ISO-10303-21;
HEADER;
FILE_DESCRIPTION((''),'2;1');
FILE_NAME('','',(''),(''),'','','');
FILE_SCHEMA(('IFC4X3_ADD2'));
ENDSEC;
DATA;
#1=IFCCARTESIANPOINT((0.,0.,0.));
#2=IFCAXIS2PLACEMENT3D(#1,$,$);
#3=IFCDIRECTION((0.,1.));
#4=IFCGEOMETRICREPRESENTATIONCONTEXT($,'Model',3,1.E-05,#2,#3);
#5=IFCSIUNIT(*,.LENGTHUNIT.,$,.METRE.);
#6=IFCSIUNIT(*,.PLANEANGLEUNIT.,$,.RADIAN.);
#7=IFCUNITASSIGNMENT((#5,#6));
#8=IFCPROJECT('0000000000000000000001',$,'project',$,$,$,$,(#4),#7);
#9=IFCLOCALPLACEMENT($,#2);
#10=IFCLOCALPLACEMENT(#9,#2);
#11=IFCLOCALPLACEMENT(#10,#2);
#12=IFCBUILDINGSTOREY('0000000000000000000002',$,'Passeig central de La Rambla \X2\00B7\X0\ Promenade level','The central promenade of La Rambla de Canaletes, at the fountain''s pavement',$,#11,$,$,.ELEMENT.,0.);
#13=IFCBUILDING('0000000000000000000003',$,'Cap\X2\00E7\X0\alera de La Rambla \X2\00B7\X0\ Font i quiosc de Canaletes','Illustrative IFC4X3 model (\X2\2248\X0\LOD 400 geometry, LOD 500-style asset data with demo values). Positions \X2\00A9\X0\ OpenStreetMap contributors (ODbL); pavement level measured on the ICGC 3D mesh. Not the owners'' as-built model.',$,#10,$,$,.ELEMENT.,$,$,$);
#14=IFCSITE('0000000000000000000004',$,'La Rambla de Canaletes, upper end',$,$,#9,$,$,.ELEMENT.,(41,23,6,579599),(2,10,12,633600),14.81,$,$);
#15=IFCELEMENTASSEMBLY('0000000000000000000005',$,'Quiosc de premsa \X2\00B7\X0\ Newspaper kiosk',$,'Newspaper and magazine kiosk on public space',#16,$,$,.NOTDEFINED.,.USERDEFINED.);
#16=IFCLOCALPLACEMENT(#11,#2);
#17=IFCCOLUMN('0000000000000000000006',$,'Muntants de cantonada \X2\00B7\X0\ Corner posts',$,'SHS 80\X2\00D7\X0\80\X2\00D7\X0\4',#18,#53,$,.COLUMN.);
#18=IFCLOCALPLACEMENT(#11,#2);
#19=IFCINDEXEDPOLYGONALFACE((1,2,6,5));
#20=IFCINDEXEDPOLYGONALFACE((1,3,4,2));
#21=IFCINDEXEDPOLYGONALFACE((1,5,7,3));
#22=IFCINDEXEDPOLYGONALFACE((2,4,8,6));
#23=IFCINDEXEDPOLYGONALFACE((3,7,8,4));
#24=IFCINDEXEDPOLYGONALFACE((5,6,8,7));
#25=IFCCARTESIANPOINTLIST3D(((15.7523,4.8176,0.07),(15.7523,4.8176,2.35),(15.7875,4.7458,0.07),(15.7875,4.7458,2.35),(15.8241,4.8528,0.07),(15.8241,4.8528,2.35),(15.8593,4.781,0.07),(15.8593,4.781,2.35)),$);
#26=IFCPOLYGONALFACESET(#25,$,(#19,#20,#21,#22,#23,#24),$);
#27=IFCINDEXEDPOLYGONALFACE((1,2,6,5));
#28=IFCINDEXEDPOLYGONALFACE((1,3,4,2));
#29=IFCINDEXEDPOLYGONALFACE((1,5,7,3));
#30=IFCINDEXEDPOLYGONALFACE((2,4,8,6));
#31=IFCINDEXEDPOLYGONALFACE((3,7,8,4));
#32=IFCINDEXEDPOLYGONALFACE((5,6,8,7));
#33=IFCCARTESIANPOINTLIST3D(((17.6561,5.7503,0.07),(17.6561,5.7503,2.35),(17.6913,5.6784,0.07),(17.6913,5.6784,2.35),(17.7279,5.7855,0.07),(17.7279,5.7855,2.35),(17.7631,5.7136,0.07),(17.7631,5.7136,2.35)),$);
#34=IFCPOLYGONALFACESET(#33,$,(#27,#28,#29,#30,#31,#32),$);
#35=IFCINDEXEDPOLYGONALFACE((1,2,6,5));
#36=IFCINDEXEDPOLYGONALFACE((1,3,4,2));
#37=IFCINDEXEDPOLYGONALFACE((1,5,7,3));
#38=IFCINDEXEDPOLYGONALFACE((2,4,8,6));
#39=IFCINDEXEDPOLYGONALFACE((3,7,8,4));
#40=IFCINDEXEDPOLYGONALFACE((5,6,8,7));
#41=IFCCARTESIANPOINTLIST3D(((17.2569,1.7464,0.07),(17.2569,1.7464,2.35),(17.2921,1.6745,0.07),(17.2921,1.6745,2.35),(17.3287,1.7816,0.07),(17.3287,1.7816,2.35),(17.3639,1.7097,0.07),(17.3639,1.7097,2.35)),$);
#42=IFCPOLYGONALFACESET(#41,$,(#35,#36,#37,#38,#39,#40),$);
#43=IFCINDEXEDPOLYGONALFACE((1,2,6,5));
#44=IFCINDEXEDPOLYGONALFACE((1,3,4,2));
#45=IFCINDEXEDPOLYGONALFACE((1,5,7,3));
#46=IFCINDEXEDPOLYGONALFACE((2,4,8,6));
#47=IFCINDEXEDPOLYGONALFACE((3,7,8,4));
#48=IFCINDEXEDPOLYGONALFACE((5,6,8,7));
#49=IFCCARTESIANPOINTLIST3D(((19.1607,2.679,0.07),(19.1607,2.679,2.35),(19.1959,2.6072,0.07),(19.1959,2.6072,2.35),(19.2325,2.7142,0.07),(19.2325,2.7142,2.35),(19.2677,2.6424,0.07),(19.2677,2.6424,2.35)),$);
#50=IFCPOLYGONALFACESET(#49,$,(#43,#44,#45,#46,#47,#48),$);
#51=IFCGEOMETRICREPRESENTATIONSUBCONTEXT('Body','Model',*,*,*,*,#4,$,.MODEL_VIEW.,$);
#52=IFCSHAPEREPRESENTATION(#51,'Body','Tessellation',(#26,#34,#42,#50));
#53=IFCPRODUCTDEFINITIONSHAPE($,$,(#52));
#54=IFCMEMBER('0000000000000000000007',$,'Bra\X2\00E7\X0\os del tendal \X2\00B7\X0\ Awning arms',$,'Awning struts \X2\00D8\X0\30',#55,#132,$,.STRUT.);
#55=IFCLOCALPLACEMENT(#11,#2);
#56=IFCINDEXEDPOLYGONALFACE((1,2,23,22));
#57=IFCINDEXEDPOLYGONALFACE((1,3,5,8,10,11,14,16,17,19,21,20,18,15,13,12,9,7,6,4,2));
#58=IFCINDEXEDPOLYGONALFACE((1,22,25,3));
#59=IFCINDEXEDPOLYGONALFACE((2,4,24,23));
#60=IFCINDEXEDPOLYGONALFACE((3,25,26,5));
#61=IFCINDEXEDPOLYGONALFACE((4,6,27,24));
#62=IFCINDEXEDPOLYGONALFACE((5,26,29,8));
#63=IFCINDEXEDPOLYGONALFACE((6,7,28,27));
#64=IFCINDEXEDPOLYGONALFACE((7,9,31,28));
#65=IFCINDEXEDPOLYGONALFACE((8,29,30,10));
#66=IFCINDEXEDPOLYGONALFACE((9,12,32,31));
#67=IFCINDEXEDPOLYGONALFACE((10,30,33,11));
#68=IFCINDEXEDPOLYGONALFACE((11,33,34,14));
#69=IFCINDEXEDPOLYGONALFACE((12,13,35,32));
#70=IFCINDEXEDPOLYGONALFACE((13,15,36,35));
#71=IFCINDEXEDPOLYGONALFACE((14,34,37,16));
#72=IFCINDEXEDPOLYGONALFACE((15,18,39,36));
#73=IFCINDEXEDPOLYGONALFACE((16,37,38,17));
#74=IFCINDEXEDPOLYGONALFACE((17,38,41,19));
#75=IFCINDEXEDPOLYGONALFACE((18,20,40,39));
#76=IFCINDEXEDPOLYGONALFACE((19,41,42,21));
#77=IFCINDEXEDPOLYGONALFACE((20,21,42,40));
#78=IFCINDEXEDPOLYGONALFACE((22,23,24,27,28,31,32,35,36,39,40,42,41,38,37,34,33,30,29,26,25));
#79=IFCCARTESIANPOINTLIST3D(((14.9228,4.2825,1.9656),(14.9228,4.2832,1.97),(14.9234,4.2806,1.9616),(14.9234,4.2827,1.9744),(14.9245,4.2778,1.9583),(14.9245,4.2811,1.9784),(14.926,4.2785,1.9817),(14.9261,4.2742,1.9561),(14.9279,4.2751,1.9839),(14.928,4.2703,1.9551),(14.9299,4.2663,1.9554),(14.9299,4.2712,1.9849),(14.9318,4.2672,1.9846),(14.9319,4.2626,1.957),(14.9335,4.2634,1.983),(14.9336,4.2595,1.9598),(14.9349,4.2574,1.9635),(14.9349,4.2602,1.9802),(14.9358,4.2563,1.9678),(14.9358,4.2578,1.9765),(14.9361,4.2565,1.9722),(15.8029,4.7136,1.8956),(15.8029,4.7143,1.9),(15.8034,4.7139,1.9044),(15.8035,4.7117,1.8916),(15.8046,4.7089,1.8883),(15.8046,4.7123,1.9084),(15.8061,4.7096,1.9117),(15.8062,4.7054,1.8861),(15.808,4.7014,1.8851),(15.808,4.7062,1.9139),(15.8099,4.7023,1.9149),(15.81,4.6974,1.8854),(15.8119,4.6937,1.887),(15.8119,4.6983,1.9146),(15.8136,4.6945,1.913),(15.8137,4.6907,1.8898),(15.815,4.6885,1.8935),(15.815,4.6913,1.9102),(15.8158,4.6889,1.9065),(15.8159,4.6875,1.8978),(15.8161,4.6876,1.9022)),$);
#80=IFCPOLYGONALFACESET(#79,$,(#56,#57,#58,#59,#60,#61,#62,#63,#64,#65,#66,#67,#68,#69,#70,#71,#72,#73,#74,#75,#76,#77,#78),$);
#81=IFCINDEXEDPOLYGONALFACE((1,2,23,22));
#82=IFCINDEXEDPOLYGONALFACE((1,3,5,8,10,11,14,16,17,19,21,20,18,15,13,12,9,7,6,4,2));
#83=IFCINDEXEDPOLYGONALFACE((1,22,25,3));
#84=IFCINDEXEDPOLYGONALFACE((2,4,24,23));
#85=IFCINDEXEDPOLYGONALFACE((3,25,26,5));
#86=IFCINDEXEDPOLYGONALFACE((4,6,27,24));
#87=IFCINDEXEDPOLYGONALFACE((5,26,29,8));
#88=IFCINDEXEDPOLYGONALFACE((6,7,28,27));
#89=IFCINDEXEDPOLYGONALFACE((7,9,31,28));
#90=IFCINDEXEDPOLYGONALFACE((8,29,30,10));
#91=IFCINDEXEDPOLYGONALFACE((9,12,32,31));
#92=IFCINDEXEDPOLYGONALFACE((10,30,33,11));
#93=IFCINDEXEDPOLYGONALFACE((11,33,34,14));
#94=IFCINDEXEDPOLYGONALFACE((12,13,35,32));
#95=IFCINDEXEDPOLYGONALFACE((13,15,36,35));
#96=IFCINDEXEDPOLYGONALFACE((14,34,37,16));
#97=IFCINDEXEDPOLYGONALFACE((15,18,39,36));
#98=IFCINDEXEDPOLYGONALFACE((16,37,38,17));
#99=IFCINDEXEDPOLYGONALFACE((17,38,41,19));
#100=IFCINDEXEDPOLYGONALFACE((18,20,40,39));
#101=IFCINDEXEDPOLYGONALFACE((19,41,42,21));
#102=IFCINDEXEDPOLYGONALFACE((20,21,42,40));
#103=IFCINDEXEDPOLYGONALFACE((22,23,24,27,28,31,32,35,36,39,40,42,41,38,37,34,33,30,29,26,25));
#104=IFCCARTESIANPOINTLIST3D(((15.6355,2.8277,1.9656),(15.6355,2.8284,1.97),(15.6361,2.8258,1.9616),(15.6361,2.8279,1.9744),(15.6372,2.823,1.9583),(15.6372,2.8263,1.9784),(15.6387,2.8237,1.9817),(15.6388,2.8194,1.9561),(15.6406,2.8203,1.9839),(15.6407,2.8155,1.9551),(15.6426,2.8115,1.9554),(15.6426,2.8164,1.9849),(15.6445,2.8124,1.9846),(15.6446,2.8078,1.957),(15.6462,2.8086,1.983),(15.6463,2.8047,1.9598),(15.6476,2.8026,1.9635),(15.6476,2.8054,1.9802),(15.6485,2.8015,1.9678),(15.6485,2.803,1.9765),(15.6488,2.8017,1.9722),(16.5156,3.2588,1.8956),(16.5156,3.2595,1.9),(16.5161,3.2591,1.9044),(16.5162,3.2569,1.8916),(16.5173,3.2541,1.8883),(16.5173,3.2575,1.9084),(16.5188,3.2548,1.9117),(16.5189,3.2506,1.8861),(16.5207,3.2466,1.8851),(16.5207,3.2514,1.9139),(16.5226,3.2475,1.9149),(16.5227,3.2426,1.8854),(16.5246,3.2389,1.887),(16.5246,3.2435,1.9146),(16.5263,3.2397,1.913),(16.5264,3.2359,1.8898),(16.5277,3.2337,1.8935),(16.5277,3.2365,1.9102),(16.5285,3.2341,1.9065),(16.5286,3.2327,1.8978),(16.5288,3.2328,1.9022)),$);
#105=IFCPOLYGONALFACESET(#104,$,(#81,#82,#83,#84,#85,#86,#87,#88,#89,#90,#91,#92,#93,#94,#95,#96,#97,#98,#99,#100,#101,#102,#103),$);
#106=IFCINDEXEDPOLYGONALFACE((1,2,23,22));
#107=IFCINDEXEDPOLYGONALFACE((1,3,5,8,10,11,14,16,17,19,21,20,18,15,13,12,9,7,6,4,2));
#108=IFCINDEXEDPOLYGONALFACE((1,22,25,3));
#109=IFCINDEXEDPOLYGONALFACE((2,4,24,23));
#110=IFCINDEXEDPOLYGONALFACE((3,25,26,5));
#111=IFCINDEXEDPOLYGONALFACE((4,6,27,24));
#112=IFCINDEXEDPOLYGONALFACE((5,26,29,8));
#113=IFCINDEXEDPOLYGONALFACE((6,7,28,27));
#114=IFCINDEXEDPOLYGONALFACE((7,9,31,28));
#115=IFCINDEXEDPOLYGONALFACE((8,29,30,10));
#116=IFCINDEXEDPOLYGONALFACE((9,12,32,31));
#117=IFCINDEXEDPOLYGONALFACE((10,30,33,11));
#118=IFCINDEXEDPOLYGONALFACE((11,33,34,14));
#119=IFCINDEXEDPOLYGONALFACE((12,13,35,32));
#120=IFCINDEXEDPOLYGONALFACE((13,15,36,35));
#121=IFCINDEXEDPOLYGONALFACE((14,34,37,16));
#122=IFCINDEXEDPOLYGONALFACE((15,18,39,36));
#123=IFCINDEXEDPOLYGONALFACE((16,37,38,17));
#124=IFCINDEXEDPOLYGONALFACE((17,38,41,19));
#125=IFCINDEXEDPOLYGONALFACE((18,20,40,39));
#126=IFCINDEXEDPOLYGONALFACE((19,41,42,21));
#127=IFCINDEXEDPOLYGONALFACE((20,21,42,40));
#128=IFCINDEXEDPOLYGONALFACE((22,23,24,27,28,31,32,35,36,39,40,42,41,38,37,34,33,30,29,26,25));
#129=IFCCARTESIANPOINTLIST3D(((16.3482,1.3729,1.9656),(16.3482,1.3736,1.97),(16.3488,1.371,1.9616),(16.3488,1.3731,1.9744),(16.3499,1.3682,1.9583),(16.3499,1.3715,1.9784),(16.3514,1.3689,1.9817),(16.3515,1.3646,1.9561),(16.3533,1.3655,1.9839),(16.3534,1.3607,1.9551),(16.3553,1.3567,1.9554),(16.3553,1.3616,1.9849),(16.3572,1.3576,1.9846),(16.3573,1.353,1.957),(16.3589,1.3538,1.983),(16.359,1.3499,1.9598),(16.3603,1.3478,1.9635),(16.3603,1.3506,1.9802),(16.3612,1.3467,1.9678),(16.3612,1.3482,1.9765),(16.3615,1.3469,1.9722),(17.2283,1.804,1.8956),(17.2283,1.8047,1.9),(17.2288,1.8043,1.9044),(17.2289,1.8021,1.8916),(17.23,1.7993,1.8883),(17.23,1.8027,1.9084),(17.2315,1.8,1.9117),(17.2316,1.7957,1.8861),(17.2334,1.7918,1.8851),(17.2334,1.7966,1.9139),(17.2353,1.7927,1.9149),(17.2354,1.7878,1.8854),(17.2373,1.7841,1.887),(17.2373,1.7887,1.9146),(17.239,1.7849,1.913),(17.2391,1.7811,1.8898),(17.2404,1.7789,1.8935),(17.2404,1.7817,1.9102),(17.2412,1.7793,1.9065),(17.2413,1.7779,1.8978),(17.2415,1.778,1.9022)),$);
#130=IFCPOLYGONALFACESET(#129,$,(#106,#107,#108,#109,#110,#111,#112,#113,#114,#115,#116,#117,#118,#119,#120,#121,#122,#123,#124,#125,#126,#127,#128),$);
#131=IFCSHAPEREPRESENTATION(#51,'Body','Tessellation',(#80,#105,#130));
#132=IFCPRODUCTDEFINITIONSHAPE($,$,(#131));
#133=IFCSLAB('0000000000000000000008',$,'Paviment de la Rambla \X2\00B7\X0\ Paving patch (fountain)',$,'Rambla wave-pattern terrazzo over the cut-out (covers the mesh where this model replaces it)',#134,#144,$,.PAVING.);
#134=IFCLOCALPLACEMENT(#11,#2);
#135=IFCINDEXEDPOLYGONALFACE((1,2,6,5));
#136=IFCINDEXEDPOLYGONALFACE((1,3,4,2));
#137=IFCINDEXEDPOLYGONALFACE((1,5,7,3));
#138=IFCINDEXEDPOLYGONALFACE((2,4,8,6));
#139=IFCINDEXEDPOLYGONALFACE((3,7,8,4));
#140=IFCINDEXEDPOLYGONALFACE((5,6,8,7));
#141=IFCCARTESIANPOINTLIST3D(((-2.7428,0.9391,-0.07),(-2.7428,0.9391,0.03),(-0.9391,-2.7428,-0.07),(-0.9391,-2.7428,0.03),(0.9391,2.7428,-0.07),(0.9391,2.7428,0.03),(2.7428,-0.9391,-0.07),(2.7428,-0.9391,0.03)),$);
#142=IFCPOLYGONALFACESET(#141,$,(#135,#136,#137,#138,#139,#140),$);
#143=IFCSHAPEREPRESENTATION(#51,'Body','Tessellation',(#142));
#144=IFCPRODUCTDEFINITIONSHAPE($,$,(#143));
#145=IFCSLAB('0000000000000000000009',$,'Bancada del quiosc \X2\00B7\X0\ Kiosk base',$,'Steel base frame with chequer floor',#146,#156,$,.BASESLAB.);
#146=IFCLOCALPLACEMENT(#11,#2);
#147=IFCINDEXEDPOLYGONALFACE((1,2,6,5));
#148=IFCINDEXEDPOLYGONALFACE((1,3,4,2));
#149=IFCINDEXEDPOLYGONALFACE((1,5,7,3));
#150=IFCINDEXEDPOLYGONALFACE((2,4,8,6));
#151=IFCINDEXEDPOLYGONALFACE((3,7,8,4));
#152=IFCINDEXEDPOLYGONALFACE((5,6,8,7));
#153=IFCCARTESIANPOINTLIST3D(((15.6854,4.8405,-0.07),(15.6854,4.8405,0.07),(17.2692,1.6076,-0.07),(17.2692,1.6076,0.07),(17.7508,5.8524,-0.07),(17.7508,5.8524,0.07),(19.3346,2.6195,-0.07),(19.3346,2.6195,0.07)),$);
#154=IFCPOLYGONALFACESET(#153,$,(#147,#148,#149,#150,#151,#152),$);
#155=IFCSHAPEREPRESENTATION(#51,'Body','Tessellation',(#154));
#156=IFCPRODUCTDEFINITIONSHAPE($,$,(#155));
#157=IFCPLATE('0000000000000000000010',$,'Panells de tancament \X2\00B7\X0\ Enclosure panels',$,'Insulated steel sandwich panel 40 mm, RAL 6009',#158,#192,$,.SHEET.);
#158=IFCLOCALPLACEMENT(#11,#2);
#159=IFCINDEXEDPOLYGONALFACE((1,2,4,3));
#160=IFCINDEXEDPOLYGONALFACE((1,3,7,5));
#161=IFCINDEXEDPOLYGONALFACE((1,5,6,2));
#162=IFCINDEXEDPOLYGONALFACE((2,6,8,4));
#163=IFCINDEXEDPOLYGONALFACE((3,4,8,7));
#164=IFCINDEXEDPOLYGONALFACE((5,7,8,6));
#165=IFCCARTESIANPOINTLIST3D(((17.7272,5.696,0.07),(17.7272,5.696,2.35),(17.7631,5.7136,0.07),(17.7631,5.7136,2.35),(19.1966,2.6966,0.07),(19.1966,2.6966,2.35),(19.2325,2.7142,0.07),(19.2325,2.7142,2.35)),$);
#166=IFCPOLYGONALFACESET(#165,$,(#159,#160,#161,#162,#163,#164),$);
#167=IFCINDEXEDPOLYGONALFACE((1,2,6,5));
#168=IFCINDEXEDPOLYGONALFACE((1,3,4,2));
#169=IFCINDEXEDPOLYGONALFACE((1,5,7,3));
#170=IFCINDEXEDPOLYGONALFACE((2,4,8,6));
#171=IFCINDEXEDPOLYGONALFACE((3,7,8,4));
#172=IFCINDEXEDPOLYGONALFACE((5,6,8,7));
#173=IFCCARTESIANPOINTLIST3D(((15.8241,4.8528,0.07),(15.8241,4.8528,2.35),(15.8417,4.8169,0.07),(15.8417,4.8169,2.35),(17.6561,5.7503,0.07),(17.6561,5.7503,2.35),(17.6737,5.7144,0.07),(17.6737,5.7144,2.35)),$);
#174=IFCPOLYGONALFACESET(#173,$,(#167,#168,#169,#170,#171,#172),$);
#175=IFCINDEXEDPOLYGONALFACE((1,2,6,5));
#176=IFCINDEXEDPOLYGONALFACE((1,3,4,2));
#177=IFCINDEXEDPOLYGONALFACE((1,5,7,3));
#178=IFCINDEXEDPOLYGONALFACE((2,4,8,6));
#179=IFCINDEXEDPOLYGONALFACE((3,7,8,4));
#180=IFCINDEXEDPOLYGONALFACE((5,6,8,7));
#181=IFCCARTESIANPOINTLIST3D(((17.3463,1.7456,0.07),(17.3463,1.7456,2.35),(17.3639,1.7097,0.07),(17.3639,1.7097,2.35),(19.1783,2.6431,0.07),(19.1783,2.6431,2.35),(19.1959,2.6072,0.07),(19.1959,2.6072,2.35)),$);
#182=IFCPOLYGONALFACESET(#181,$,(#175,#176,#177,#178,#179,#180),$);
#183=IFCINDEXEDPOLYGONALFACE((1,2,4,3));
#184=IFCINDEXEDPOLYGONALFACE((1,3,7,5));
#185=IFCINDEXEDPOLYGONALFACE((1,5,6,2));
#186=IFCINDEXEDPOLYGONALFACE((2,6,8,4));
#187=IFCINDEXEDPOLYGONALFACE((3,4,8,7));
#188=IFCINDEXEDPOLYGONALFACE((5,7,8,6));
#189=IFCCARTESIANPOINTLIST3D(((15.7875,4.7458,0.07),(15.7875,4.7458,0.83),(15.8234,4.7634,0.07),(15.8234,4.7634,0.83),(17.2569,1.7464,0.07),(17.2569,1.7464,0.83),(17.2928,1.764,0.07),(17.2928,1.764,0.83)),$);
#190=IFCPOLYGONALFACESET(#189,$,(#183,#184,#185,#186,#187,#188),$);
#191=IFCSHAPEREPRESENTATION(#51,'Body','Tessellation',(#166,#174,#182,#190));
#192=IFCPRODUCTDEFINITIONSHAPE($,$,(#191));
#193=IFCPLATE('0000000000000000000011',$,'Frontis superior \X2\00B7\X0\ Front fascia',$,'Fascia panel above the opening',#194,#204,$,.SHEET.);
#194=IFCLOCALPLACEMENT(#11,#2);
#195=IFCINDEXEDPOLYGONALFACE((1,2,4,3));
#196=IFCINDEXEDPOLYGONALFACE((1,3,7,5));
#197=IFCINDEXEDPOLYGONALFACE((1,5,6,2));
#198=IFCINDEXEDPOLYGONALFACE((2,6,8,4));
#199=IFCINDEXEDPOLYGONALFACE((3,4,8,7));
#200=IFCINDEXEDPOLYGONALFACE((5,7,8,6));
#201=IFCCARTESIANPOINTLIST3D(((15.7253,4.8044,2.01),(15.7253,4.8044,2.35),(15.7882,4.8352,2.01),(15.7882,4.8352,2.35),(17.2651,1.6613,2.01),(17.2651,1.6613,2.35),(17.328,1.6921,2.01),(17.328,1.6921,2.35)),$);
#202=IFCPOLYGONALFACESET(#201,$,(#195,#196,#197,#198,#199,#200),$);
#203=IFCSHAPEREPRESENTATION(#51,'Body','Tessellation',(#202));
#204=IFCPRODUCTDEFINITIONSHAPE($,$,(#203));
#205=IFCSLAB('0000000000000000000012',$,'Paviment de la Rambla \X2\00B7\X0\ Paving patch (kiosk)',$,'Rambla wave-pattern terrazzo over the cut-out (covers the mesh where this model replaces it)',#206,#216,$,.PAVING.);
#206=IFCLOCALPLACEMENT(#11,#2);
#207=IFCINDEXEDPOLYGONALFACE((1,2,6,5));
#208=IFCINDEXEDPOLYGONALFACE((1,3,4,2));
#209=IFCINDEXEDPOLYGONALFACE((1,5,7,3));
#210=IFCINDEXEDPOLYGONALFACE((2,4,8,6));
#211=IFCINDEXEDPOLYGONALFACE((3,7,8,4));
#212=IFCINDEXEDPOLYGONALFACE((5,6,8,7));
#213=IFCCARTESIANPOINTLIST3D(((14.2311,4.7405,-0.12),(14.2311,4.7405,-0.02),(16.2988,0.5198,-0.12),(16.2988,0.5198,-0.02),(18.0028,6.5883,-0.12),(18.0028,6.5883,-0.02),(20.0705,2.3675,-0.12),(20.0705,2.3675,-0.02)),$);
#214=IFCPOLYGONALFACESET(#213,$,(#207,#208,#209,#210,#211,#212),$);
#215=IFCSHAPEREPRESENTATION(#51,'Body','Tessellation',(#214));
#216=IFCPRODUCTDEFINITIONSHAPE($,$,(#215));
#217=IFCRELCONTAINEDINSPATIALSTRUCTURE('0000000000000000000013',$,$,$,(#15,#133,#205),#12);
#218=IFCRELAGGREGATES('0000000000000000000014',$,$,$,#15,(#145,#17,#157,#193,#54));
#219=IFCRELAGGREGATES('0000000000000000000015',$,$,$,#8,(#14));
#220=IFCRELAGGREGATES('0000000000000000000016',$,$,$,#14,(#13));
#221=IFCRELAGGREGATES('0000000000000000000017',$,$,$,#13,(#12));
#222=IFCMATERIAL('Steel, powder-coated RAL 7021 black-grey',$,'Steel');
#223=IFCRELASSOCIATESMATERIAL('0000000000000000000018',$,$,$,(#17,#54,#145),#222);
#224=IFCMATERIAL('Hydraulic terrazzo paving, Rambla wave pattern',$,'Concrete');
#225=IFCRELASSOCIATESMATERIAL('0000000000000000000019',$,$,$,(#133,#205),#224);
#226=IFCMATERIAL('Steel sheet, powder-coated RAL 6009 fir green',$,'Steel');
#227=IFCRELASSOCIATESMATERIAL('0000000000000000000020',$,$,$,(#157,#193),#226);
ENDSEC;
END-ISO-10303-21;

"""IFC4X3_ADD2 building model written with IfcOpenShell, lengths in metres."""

from ifc_helpers import new_model, si_unit, direction, frame, frame_2d, origin, origin_2d_with_axis, place, context, subcontext, project, spatial, rectangle, circle, extrude, material, element, aggregate, save


model = new_model("IFC4X3_ADD2")

# Units and contexts
model_context = context("Model", 3, precision=1e-05, world=origin(), true_north=direction((0.0, 1.0)))
body_context = subcontext(model_context, "Body", "Model", "MODEL_VIEW")
ifc_project = project(units=[si_unit("LENGTHUNIT", "METRE"), si_unit("PLANEANGLEUNIT", "RADIAN")], contexts=[model_context])

# Site, building, storey
site_placement = place(None, origin())
site = spatial("IfcSite", under=ifc_project, at=site_placement, Name="La Rambla de Canaletes, upper end", CompositionType="ELEMENT", RefLatitude=(41, 23, 6, 579599), RefLongitude=(2, 10, 12, 633600), RefElevation=14.81)
building_placement = place(site_placement, origin())
building = spatial("IfcBuilding", under=site, at=building_placement, Name="Capçalera de La Rambla · Font i quiosc de Canaletes", Description="Illustrative IFC4X3 model (≈LOD 400 geometry, LOD 500-style asset data with demo values). Positions © OpenStreetMap contributors (ODbL); pavement level measured on the ICGC 3D mesh. Not the owners' as-built model.", CompositionType="ELEMENT")
storey_placement = place(building_placement, origin())
storey = spatial("IfcBuildingStorey", under=building, at=storey_placement, Name="Passeig central de La Rambla · Promenade level", Description="The central promenade of La Rambla de Canaletes, at the fountain's pavement", CompositionType="ELEMENT", Elevation=0.0)

# Element assembly, column, member
assembly_1_placement = place(building_placement, origin())
assembly_1 = element("IfcElementAssembly", 1, at=assembly_1_placement, inside=storey, Name="Quiosc de premsa · Newspaper kiosk", ObjectType="Newspaper and magazine kiosk on public space", AssemblyPlace="NOTDEFINED", PredefinedType="USERDEFINED")
ifc_material_1 = material(Name="Steel, powder-coated RAL 7021 black-grey", Category="Steel")
column_placement = place(building_placement, origin())
column = element("IfcColumn", 2, at=column_placement, material=ifc_material_1, Name="Muntants de cantonada · Corner posts", ObjectType="SHS 80×80×4", PredefinedType="COLUMN", context=body_context, shape_type="SweptSolid", body=[
    extrude(rectangle(XDim=0.08, YDim=0.08, at=frame_2d((0.0, 0.0), x_axis=(0.439939, -0.898028))), frame((15.8058, 4.7993, 0.07)), (0.0, 0.0, 1.0), 2.28),
    extrude(rectangle(XDim=0.08, YDim=0.08, at=frame_2d((0.0, 0.0), x_axis=(0.439939, -0.898028))), frame((17.7096, 5.732, 0.07)), (0.0, 0.0, 1.0), 2.28),
    extrude(rectangle(XDim=0.08, YDim=0.08, at=frame_2d((0.0, 0.0), x_axis=(0.439939, -0.898028))), frame((17.3104, 1.728, 0.07)), (0.0, 0.0, 1.0), 2.28),
    extrude(rectangle(XDim=0.08, YDim=0.08, at=frame_2d((0.0, 0.0), x_axis=(0.439939, -0.898028))), frame((19.2142, 2.6607, 0.07)), (0.0, 0.0, 1.0), 2.28),
])
member_placement = place(building_placement, origin())
member = element("IfcMember", 3, at=member_placement, material=ifc_material_1, Name="Braços del tendal · Awning arms", ObjectType="Awning struts Ø30", PredefinedType="STRUT", context=body_context, shape_type="SweptSolid", body=[
    extrude(circle(Radius=0.015, at=origin_2d_with_axis()), frame((15.8095, 4.7009, 1.9), z_axis=(-0.895745, -0.438821, 0.071247), x_axis=(-0.439939, 0.898028, 0.0)), (0.0, 0.0, 1.0), 0.9825),
    extrude(circle(Radius=0.015, at=origin_2d_with_axis()), frame((16.5222, 3.2461, 1.9), z_axis=(-0.895745, -0.438821, 0.071247), x_axis=(-0.439939, 0.898028, 0.0)), (0.0, 0.0, 1.0), 0.9825),
    extrude(circle(Radius=0.015, at=origin_2d_with_axis()), frame((17.2349, 1.7913, 1.9), z_axis=(-0.895745, -0.438821, 0.071247), x_axis=(-0.439939, 0.898028, 0.0)), (0.0, 0.0, 1.0), 0.9825),
])

# Slabs
ifc_material_2 = material(Name="Hydraulic terrazzo paving, Rambla wave pattern", Category="Concrete")
slab_1_placement = place(building_placement, origin())
element("IfcSlab", 4, at=slab_1_placement, inside=storey, material=ifc_material_2, Name="Paviment de la Rambla · Paving patch (fountain)", ObjectType="Rambla wave-pattern terrazzo over the cut-out (covers the mesh where this model replaces it)", PredefinedType="PAVING", context=body_context, shape_type="SweptSolid", body=[
    extrude(rectangle(XDim=4.1, YDim=4.1, at=frame_2d((0.0, 0.0), x_axis=(0.439939, -0.898028))), frame((0.0, 0.0, -0.07)), (0.0, 0.0, 1.0), 0.1),
])
slab_2_placement = place(building_placement, origin())
slab_2 = element("IfcSlab", 5, at=slab_2_placement, material=ifc_material_1, Name="Bancada del quiosc · Kiosk base", ObjectType="Steel base frame with chequer floor", PredefinedType="BASESLAB", context=body_context, shape_type="SweptSolid", body=[
    extrude(rectangle(XDim=3.6, YDim=2.3, at=frame_2d((0.0, 0.0), x_axis=(0.439939, -0.898028))), frame((17.51, 3.73, -0.07)), (0.0, 0.0, 1.0), 0.14),
])

# Plates
ifc_material_3 = material(Name="Steel sheet, powder-coated RAL 6009 fir green", Category="Steel")
plate_1_placement = place(building_placement, origin())
plate_1 = element("IfcPlate", 6, at=plate_1_placement, material=ifc_material_3, Name="Panells de tancament · Enclosure panels", ObjectType="Insulated steel sandwich panel 40 mm, RAL 6009", PredefinedType="SHEET", context=body_context, shape_type="SweptSolid", body=[
    extrude(rectangle(XDim=3.34, YDim=0.04, at=frame_2d((0.0, 0.0), x_axis=(0.439939, -0.898028))), frame((18.4799, 4.2051, 0.07)), (0.0, 0.0, 1.0), 2.28),
    extrude(rectangle(XDim=0.04, YDim=2.04, at=frame_2d((0.0, 0.0), x_axis=(0.439939, -0.898028))), frame((16.7489, 5.2836, 0.07)), (0.0, 0.0, 1.0), 2.28),
    extrude(rectangle(XDim=0.04, YDim=2.04, at=frame_2d((0.0, 0.0), x_axis=(0.439939, -0.898028))), frame((18.2711, 2.1764, 0.07)), (0.0, 0.0, 1.0), 2.28),
    extrude(rectangle(XDim=3.34, YDim=0.04, at=frame_2d((0.0, 0.0), x_axis=(0.439939, -0.898028))), frame((16.5401, 3.2549, 0.07)), (0.0, 0.0, 1.0), 0.76),
])
plate_2_placement = place(building_placement, origin())
plate_2 = element("IfcPlate", 7, at=plate_2_placement, material=ifc_material_3, Name="Frontis superior · Front fascia", ObjectType="Fascia panel above the opening", PredefinedType="SHEET", context=body_context, shape_type="SweptSolid", body=[
    extrude(rectangle(XDim=3.5, YDim=0.07, at=frame_2d((0.0, 0.0), x_axis=(0.439939, -0.898028))), frame((16.5267, 3.2483, 2.01)), (0.0, 0.0, 1.0), 0.34),
])

# Slab
slab_3_placement = place(building_placement, origin())
element("IfcSlab", 8, at=slab_3_placement, inside=storey, material=ifc_material_2, Name="Paviment de la Rambla · Paving patch (kiosk)", ObjectType="Rambla wave-pattern terrazzo over the cut-out (covers the mesh where this model replaces it)", PredefinedType="PAVING", context=body_context, shape_type="SweptSolid", body=[
    extrude(rectangle(XDim=4.7, YDim=4.2, at=frame_2d((0.0, 0.0), x_axis=(0.439939, -0.898028))), frame((17.1508, 3.554, -0.12)), (0.0, 0.0, 1.0), 0.1),
])

aggregate(assembly_1, [slab_2, column, plate_1, plate_2, member])

save(model, "model.ifc")
